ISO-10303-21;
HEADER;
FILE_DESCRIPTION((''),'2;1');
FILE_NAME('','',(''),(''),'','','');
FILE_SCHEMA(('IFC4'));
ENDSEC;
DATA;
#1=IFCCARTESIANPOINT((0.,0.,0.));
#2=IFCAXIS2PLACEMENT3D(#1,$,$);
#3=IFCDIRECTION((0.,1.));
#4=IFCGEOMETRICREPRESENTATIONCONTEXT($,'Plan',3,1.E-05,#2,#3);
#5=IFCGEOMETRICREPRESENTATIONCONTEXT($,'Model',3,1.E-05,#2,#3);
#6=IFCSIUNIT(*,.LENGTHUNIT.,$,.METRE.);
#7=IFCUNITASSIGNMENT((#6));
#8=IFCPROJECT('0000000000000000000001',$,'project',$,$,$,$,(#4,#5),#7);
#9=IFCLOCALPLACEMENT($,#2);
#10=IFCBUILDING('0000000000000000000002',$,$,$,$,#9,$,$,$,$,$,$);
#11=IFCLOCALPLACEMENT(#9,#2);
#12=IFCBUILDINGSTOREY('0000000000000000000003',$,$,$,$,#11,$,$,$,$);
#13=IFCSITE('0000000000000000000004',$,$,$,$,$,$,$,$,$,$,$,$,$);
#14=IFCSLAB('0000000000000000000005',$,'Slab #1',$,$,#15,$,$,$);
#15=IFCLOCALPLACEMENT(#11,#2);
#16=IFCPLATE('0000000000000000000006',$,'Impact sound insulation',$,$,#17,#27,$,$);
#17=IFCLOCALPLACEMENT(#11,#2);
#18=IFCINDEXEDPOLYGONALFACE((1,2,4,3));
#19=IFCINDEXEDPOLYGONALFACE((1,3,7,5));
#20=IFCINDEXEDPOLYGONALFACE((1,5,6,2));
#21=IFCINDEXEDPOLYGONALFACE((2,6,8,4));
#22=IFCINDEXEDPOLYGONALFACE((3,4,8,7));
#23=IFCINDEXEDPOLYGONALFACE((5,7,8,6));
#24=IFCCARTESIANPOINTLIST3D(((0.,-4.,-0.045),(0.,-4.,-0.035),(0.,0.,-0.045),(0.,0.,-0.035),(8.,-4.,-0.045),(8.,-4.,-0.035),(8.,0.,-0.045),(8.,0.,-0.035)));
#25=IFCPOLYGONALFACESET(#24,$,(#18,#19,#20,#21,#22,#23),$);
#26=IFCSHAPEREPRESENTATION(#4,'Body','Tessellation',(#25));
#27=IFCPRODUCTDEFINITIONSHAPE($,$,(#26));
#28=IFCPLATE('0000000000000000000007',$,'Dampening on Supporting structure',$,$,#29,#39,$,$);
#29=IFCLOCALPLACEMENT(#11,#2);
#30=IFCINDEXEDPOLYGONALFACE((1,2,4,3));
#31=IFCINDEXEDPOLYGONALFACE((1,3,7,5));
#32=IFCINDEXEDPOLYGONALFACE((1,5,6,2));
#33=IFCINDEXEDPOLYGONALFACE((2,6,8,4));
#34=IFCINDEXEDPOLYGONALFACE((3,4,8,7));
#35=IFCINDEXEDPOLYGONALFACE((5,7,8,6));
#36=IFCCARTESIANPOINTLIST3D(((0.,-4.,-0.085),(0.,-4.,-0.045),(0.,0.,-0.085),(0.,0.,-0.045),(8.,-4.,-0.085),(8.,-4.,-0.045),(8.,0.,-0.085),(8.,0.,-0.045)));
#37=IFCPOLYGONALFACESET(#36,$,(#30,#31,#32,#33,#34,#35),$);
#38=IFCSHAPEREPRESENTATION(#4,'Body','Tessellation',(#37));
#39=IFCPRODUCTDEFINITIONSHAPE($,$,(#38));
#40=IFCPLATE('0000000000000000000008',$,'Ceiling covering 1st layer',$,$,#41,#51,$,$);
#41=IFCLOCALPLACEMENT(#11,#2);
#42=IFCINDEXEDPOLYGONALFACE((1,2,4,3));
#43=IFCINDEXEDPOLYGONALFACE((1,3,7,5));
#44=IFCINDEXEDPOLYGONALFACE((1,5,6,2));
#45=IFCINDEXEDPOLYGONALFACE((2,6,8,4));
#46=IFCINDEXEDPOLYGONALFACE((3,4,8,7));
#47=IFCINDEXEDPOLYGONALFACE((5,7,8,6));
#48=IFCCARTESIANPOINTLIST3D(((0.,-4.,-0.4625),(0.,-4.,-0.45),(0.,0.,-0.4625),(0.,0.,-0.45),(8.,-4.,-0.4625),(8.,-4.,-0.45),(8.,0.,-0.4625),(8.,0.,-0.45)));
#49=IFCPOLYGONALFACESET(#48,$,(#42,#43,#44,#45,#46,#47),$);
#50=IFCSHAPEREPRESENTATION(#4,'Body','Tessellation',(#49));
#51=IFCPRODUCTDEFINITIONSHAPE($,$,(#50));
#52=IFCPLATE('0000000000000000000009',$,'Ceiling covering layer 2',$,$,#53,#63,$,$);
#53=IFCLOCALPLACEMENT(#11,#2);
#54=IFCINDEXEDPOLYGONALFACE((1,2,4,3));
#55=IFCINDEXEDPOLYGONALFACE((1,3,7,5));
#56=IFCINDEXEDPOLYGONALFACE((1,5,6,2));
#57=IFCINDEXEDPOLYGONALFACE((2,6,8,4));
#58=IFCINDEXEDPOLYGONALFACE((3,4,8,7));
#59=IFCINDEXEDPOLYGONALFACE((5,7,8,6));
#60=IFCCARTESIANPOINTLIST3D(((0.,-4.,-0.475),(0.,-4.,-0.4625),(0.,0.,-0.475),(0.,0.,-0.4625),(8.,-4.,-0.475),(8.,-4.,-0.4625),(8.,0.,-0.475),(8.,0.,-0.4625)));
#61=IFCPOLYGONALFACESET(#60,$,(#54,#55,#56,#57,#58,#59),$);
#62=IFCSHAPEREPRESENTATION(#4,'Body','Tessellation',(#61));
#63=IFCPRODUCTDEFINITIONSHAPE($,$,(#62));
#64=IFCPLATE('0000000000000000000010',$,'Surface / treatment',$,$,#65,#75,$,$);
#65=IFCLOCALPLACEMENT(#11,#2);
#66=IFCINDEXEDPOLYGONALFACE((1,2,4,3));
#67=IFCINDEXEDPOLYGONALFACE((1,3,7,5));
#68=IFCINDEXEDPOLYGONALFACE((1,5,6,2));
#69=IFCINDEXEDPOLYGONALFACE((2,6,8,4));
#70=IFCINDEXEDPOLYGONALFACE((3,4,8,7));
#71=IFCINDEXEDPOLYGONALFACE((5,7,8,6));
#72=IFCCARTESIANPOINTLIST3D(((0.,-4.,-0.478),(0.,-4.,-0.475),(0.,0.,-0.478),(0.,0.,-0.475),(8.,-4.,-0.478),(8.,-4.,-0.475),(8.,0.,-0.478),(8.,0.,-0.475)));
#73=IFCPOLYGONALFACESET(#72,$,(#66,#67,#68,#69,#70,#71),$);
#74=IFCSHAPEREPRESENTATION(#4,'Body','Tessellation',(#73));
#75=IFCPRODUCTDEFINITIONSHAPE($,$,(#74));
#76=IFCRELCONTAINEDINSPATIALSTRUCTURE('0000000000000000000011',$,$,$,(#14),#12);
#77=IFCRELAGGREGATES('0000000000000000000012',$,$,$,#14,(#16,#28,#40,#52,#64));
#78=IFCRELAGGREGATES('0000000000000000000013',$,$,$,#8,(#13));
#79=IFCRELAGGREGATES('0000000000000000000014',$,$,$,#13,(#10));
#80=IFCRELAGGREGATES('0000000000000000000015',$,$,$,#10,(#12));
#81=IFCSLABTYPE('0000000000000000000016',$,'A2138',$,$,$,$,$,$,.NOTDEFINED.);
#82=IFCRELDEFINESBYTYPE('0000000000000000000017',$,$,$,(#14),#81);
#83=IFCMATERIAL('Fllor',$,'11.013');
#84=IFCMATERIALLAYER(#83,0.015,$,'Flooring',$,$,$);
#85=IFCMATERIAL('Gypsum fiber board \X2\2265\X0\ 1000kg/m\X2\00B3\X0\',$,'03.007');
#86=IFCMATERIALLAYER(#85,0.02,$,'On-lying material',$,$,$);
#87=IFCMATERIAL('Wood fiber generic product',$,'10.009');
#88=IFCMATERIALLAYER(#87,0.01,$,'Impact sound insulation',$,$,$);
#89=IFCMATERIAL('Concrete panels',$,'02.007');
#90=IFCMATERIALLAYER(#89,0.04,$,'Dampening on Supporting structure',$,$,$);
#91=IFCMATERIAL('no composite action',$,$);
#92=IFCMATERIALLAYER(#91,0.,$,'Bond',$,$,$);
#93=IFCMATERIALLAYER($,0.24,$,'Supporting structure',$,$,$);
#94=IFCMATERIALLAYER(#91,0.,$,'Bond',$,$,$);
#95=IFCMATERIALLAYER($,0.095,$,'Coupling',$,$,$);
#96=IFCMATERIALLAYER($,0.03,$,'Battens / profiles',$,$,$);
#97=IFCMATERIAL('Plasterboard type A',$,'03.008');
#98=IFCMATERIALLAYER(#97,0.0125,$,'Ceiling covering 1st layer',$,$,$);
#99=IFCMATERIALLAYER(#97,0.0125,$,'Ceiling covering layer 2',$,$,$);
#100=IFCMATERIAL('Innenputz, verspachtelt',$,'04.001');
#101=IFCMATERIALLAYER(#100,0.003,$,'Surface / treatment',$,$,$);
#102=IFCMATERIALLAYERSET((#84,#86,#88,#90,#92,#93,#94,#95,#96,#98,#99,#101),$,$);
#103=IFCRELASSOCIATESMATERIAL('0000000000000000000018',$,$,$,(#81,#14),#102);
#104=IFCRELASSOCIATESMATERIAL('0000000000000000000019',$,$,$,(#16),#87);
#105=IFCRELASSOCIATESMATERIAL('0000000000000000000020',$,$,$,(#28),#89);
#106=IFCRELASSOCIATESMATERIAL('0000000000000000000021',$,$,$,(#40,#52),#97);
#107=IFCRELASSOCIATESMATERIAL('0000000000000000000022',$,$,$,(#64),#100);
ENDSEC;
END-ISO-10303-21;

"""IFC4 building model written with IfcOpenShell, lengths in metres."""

from ifc_helpers import new_model, si_unit, direction, frame, frame_2d, origin, place, context, project, spatial, rectangle, extrude, material, layer, layer_set, type_object, element, aggregate, save


model = new_model("IFC4")

# Units and contexts
plan_context = context("Plan", 3, precision=1e-05, world=origin(), true_north=direction((0.0, 1.0)))
model_context = context("Model", 3, precision=1e-05, world=origin(), true_north=direction((0.0, 1.0)))
ifc_project = project(units=[si_unit("LENGTHUNIT", "METRE")], contexts=[plan_context, model_context])

# Site, building, storey
site = spatial("IfcSite", under=ifc_project)
building_placement = place(None, origin())
building = spatial("IfcBuilding", under=site, at=building_placement)
storey_placement = place(building_placement, origin())
storey = spatial("IfcBuildingStorey", under=building, at=storey_placement)

# Slab, plates
ifc_material_1 = material(Name="Fllor", Category="11.013")
ifc_layer_1 = layer(ifc_material_1, 0.015, Name="Flooring")
ifc_material_2 = material(Name="Gypsum fiber board ≥ 1000kg/m³", Category="03.007")
ifc_layer_2 = layer(ifc_material_2, 0.02, Name="On-lying material")
ifc_material_3 = material(Name="Wood fiber generic product", Category="10.009")
ifc_layer_3 = layer(ifc_material_3, 0.01, Name="Impact sound insulation")
ifc_material_4 = material(Name="Concrete panels", Category="02.007")
ifc_layer_4 = layer(ifc_material_4, 0.04, Name="Dampening on Supporting structure")
ifc_material_5 = material(Name="no composite action")
ifc_layer_5 = layer(ifc_material_5, 0.0, Name="Bond")
ifc_layer_6 = layer(None, 0.24, Name="Supporting structure")
ifc_layer_7 = layer(ifc_material_5, 0.0, Name="Bond")
ifc_layer_8 = layer(None, 0.095, Name="Coupling")
ifc_layer_9 = layer(None, 0.03, Name="Battens / profiles")
ifc_material_6 = material(Name="Plasterboard type A", Category="03.008")
ifc_layer_10 = layer(ifc_material_6, 0.0125, Name="Ceiling covering 1st layer")
ifc_layer_11 = layer(ifc_material_6, 0.0125, Name="Ceiling covering layer 2")
ifc_material_7 = material(Name="Innenputz, verspachtelt", Category="04.001")
ifc_layer_12 = layer(ifc_material_7, 0.003, Name="Surface / treatment")
ifc_layer_set = layer_set([ifc_layer_1, ifc_layer_2, ifc_layer_3, ifc_layer_4, ifc_layer_5, ifc_layer_6, ifc_layer_7, ifc_layer_8, ifc_layer_9, ifc_layer_10, ifc_layer_11, ifc_layer_12])
slab_type = type_object("IfcSlabType", Name="A2138", PredefinedType="NOTDEFINED", material=ifc_layer_set)
slab_placement = place(None, frame((0.0, 0.0, 0.0), z_axis=(0.0, 0.0, -1.0), x_axis=(1.0, 0.0, 0.0)))
slab = element("IfcSlab", 1, at=slab_placement, inside=storey, type_object=slab_type, material=ifc_layer_set, Name="Slab #1")
plate_1_placement = place(slab_placement, origin())
plate_1 = element("IfcPlate", 2, at=plate_1_placement, material=ifc_material_3, Name="Impact sound insulation", context=plan_context, shape_type="SweptSolid", body=[
    extrude(rectangle(XDim=8.0, YDim=4.0, at=frame_2d((4.0, 2.0), x_axis=(1.0, 0.0))), frame((0.0, 0.0, 0.035), z_axis=(0.0, 0.0, 1.0), x_axis=(1.0, 0.0, 0.0)), (0.0, 0.0, 1.0), 0.01),
])
plate_2_placement = place(slab_placement, origin())
plate_2 = element("IfcPlate", 3, at=plate_2_placement, material=ifc_material_4, Name="Dampening on Supporting structure", context=plan_context, shape_type="SweptSolid", body=[
    extrude(rectangle(XDim=8.0, YDim=4.0, at=frame_2d((4.0, 2.0), x_axis=(1.0, 0.0))), frame((0.0, 0.0, 0.045), z_axis=(0.0, 0.0, 1.0), x_axis=(1.0, 0.0, 0.0)), (0.0, 0.0, 1.0), 0.04),
])
plate_3_placement = place(slab_placement, origin())
plate_3 = element("IfcPlate", 4, at=plate_3_placement, material=ifc_material_6, Name="Ceiling covering 1st layer", context=plan_context, shape_type="SweptSolid", body=[
    extrude(rectangle(XDim=8.0, YDim=4.0, at=frame_2d((4.0, 2.0), x_axis=(1.0, 0.0))), frame((0.0, 0.0, 0.45), z_axis=(0.0, 0.0, 1.0), x_axis=(1.0, 0.0, 0.0)), (0.0, 0.0, 1.0), 0.0125),
])
plate_4_placement = place(slab_placement, origin())
plate_4 = element("IfcPlate", 5, at=plate_4_placement, material=ifc_material_6, Name="Ceiling covering layer 2", context=plan_context, shape_type="SweptSolid", body=[
    extrude(rectangle(XDim=8.0, YDim=4.0, at=frame_2d((4.0, 2.0), x_axis=(1.0, 0.0))), frame((0.0, 0.0, 0.4625), z_axis=(0.0, 0.0, 1.0), x_axis=(1.0, 0.0, 0.0)), (0.0, 0.0, 1.0), 0.0125),
])
plate_5_placement = place(slab_placement, origin())
plate_5 = element("IfcPlate", 6, at=plate_5_placement, material=ifc_material_7, Name="Surface / treatment", context=plan_context, shape_type="SweptSolid", body=[
    extrude(rectangle(XDim=8.0, YDim=4.0, at=frame_2d((4.0, 2.0), x_axis=(1.0, 0.0))), frame((0.0, 0.0, 0.475), z_axis=(0.0, 0.0, 1.0), x_axis=(1.0, 0.0, 0.0)), (0.0, 0.0, 1.0), 0.003),
])
aggregate(slab, [plate_1, plate_2, plate_3, plate_4, plate_5])

save(model, "model.ifc")
